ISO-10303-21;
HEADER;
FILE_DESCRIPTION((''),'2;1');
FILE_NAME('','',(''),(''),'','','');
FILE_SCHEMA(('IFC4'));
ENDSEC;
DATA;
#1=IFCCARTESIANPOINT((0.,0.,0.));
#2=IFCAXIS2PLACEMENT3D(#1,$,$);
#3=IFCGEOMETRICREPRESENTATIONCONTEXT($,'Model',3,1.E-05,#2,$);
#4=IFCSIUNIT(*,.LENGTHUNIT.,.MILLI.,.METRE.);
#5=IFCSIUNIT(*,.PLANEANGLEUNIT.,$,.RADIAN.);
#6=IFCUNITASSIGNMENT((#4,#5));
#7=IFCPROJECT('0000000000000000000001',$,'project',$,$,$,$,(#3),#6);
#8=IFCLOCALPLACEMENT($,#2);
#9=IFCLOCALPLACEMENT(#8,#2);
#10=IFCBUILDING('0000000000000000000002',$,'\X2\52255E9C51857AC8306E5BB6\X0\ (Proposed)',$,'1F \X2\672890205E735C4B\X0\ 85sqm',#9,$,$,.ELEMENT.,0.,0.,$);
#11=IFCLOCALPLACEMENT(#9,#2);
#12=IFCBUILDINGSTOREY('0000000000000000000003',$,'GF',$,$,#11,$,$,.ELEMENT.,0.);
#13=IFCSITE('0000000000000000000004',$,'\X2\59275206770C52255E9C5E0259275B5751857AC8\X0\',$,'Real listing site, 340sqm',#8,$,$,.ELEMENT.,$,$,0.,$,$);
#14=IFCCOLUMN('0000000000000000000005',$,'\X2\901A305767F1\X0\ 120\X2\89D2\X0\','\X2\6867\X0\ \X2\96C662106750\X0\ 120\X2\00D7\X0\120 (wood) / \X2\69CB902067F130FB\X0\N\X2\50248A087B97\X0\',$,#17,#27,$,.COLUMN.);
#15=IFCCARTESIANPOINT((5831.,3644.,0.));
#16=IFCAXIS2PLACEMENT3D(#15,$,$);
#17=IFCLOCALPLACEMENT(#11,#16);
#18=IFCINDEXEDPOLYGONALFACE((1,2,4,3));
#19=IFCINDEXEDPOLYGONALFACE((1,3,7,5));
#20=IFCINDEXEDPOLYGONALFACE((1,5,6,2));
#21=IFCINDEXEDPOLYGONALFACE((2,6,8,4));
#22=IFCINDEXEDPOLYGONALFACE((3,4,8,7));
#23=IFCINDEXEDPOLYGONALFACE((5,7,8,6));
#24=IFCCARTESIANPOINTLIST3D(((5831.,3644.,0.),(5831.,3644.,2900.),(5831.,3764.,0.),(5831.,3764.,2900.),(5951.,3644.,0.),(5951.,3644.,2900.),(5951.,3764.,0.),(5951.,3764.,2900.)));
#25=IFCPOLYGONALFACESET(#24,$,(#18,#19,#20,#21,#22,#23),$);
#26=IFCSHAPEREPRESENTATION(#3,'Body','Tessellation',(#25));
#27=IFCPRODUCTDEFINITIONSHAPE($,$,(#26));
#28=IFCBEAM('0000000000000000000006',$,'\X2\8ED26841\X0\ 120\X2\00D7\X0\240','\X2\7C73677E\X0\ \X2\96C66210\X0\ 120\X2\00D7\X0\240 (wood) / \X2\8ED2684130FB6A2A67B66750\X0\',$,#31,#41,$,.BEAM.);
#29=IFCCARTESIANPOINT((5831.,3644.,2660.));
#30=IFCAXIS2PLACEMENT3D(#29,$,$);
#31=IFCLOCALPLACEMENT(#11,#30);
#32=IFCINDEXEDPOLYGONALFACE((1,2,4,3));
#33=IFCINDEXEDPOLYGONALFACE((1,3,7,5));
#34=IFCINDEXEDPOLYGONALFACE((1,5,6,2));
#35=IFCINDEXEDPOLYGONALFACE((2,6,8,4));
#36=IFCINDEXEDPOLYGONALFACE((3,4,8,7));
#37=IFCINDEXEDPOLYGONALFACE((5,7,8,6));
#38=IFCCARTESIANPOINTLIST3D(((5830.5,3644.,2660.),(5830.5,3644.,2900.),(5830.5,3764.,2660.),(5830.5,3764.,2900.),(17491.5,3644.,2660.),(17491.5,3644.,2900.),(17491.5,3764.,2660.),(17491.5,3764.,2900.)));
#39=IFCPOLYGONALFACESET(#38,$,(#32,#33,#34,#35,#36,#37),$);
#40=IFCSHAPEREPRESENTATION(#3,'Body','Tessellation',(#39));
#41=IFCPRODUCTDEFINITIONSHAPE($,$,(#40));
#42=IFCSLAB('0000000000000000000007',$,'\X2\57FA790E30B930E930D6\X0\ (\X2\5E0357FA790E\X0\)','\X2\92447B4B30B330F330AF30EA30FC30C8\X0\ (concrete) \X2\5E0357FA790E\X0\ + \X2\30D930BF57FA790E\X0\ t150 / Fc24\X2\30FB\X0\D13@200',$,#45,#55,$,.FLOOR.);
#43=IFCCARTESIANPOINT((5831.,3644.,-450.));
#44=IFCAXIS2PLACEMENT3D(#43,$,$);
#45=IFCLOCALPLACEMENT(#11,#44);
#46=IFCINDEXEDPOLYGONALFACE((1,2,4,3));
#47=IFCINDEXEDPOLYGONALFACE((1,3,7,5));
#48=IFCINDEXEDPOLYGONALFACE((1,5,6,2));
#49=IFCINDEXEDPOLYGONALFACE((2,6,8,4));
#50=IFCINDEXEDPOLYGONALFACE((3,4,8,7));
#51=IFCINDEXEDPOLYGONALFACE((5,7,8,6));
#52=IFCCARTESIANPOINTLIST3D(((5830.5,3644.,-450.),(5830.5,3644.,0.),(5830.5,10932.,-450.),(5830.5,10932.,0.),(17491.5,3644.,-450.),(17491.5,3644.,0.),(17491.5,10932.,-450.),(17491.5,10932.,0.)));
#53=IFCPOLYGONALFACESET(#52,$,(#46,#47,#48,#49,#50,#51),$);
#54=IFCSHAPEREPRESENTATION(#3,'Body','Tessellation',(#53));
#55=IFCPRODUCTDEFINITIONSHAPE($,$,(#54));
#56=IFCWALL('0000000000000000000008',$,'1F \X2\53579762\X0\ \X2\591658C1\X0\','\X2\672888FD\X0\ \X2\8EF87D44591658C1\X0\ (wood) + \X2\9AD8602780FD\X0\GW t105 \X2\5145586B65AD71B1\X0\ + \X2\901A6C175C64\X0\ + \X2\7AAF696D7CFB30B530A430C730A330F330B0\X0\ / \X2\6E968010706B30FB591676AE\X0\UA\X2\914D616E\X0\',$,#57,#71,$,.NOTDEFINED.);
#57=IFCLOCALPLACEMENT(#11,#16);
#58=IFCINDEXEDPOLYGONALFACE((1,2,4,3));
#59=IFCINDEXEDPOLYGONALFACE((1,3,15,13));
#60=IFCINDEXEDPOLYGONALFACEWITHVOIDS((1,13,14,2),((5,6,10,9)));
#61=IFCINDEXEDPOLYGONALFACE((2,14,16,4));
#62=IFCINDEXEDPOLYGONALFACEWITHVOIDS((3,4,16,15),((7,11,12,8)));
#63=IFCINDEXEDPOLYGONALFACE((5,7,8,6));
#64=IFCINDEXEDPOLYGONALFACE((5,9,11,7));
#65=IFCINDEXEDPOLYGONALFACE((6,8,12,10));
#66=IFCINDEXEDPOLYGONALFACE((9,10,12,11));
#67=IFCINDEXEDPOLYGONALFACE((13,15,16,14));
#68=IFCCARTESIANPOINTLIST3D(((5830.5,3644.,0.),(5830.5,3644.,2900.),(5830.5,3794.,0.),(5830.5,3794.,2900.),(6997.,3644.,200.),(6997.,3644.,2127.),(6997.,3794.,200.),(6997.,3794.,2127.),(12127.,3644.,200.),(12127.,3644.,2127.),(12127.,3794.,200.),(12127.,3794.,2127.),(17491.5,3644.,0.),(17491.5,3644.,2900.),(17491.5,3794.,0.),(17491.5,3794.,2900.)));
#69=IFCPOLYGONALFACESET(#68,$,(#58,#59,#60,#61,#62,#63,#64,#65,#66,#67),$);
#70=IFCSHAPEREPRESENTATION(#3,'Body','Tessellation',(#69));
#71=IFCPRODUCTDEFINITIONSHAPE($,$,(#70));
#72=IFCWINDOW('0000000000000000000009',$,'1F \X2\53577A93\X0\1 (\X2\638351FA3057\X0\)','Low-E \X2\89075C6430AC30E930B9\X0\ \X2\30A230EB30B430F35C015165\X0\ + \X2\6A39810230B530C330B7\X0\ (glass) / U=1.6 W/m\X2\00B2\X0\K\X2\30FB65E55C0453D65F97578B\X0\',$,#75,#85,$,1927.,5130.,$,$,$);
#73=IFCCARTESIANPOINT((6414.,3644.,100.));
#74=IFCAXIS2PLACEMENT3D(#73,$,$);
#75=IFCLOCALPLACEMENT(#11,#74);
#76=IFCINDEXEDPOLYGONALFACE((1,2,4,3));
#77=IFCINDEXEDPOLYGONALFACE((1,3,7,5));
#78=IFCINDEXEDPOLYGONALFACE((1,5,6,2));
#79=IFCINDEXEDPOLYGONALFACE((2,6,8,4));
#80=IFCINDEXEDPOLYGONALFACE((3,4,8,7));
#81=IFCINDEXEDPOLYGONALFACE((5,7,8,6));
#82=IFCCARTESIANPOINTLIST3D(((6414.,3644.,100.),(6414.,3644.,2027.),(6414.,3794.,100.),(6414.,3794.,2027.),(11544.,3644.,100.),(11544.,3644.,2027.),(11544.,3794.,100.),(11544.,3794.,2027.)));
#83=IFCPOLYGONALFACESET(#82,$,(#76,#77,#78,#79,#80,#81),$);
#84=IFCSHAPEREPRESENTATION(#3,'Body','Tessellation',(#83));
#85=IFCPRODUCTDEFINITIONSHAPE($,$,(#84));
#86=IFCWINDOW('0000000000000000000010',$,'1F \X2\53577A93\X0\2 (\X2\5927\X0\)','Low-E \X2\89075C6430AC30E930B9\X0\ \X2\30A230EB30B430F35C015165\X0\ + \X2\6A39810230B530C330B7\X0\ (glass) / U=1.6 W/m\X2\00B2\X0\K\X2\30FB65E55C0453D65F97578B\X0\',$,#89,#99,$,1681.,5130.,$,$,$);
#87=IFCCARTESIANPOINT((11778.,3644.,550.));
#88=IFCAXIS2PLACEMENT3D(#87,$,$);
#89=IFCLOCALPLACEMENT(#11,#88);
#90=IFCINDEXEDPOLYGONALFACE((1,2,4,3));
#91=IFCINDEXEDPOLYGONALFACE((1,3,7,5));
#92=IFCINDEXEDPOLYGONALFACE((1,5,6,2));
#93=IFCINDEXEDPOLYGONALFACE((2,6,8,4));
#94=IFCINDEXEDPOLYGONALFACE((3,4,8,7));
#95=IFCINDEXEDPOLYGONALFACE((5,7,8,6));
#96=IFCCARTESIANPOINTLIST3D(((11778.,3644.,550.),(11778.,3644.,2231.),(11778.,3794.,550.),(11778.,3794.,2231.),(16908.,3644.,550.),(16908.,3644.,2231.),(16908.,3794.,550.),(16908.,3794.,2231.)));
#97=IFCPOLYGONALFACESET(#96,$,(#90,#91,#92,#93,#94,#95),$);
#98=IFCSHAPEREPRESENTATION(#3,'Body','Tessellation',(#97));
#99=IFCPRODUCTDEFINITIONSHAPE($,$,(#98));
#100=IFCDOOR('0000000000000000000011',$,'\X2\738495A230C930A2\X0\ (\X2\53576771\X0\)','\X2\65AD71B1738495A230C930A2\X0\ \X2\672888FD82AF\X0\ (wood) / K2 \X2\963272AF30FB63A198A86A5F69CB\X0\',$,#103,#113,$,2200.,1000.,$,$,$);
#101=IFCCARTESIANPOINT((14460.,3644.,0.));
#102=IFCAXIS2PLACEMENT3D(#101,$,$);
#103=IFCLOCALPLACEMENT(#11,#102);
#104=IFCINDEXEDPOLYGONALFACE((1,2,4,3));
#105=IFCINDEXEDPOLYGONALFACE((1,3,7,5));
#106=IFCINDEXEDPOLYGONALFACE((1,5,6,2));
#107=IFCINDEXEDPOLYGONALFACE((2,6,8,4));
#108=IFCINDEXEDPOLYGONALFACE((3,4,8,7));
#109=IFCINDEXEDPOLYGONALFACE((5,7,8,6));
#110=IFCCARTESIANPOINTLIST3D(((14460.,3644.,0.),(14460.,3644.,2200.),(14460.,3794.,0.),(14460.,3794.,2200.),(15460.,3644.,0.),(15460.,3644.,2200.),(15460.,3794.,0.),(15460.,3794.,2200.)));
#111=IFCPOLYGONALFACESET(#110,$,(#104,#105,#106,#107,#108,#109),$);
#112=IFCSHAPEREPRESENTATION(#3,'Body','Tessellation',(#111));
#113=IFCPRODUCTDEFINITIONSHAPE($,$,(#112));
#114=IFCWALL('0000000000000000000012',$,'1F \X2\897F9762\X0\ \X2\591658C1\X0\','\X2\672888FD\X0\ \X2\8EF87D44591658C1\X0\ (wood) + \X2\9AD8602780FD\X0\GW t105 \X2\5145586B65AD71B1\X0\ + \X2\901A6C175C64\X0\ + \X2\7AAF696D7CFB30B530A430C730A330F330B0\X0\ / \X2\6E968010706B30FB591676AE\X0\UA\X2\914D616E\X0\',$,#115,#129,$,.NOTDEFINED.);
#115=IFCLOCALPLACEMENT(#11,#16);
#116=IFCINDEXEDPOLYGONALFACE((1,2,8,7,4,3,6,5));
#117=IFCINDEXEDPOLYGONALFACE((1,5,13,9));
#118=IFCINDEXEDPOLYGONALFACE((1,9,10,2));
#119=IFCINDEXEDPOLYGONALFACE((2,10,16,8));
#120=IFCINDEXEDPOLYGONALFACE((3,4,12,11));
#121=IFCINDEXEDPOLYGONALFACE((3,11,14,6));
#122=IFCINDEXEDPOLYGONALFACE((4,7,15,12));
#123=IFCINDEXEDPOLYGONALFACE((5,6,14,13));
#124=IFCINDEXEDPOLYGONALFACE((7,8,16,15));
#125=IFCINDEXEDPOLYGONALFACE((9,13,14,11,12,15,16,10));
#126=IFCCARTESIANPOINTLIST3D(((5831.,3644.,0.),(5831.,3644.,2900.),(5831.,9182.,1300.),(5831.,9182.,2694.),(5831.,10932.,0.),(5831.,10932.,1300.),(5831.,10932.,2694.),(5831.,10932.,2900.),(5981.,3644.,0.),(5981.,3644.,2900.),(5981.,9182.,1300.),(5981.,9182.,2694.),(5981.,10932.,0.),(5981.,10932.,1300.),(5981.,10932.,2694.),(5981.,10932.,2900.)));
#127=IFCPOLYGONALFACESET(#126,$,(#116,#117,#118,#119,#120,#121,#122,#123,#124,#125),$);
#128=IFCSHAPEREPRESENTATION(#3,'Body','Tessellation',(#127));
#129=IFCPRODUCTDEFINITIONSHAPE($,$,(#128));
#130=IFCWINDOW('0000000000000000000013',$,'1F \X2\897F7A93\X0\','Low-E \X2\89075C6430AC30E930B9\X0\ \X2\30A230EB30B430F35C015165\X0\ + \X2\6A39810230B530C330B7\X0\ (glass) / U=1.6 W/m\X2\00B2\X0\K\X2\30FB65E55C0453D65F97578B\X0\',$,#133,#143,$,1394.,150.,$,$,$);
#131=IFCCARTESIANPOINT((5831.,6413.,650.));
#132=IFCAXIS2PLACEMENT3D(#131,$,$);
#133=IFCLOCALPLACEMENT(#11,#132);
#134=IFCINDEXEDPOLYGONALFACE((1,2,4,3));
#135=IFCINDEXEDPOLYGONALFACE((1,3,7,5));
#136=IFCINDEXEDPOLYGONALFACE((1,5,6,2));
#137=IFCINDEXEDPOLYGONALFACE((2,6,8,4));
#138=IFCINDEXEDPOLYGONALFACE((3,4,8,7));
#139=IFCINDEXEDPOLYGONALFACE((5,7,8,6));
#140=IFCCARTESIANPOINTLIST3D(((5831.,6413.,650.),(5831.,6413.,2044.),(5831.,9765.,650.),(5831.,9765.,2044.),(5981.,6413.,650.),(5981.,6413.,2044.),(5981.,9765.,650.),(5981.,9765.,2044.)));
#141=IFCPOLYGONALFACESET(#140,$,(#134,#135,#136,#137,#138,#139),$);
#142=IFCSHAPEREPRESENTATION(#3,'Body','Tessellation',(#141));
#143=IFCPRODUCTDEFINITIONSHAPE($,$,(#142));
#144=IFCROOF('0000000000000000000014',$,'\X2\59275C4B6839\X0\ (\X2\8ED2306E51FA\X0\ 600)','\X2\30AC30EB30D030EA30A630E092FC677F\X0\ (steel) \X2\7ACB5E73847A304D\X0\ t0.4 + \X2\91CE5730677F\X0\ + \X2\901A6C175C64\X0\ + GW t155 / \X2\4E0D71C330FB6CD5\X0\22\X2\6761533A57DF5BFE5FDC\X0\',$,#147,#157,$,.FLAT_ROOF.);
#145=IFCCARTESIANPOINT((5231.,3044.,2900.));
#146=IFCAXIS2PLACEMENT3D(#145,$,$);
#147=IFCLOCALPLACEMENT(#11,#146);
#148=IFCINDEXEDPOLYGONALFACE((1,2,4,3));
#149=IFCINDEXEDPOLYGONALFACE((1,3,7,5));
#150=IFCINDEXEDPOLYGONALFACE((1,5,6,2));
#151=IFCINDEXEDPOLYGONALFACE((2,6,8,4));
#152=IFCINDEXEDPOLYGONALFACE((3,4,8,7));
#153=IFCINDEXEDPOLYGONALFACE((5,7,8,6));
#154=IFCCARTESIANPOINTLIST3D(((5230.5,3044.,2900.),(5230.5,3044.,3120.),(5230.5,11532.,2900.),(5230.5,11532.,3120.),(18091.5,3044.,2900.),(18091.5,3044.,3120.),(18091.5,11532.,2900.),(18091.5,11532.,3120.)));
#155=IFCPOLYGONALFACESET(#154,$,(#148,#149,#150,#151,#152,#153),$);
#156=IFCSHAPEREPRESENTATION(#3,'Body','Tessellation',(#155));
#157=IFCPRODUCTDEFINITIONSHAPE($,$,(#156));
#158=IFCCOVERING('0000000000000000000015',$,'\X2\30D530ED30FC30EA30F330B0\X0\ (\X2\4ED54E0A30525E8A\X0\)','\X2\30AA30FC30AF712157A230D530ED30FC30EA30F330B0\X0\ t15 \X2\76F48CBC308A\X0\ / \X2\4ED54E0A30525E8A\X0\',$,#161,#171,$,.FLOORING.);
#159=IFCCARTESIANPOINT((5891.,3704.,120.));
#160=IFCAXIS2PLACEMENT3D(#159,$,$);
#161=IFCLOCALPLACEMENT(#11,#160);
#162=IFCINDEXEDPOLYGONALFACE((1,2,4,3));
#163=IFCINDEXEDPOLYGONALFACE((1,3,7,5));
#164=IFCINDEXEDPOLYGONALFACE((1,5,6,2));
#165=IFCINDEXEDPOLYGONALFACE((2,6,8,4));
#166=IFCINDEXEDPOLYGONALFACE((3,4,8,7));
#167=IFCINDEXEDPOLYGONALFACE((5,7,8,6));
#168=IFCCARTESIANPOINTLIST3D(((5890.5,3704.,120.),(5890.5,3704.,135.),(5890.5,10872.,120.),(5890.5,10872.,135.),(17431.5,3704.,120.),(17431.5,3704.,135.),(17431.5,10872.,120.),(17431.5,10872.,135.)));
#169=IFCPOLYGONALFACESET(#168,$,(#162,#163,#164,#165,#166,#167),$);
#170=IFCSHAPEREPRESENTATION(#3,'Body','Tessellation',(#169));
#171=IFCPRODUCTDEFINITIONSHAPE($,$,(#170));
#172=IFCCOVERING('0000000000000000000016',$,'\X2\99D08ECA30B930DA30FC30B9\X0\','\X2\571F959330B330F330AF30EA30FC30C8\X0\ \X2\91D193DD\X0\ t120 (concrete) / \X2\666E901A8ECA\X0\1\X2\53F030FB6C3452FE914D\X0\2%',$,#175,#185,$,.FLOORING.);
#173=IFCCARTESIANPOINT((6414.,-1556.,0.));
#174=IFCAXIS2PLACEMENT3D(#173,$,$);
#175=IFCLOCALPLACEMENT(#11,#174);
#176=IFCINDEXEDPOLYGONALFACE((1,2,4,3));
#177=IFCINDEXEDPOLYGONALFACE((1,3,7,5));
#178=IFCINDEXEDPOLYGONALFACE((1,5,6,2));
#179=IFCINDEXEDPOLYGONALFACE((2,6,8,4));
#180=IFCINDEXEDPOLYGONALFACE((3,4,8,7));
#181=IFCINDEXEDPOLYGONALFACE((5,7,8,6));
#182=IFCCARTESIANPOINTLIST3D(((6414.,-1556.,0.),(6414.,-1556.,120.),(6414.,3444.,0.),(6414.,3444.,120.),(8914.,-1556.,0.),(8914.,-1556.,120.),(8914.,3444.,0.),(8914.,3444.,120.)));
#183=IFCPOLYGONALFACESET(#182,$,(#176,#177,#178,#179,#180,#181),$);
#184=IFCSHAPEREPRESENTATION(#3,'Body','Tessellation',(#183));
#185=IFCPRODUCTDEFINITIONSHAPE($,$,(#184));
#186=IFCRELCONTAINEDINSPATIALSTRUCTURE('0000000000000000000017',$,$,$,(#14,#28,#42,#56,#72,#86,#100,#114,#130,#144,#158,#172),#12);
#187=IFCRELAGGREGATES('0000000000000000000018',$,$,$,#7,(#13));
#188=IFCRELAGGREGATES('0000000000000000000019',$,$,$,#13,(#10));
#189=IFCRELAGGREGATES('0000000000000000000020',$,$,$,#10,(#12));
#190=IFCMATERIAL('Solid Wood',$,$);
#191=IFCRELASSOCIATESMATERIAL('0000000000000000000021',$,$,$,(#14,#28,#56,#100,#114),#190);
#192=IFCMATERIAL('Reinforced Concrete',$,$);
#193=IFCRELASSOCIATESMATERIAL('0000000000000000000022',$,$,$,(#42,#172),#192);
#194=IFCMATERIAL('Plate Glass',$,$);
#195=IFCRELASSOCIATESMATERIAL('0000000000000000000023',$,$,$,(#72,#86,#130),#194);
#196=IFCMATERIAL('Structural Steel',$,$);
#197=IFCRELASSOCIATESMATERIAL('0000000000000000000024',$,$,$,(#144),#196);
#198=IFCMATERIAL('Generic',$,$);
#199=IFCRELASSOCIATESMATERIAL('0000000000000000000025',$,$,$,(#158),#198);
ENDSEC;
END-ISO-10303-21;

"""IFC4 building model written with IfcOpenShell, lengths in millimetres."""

from ifc_helpers import new_model, si_unit, frame, frame_2d, origin, place, context, project, spatial, rectangle, extrude, material, element, fill, save


model = new_model("IFC4")

# Units and contexts
model_context = context("Model", 3, precision=1e-05, world=origin())
ifc_project = project(units=[si_unit("LENGTHUNIT", "METRE", prefix="MILLI"), si_unit("PLANEANGLEUNIT", "RADIAN")], contexts=[model_context])

# Site, building, storey
site_placement = place(None, origin())
site = spatial("IfcSite", under=ifc_project, at=site_placement, Name="大分県別府市大字内竈", ObjectType="Real listing site, 340sqm", CompositionType="ELEMENT", RefElevation=0.0)
building_placement = place(site_placement, origin())
building = spatial("IfcBuilding", under=site, at=building_placement, Name="別府内竈の家 (Proposed)", ObjectType="1F 木造平屋 85sqm", CompositionType="ELEMENT", ElevationOfRefHeight=0.0, ElevationOfTerrain=0.0)
storey_placement = place(building_placement, origin())
storey = spatial("IfcBuildingStorey", under=building, at=storey_placement, Name="GF", CompositionType="ELEMENT", Elevation=0.0)

# Column
ifc_material_1 = material(Name="Solid Wood")
column_1_placement = place(storey_placement, frame((5831.0, 3644.0, 0.0)))
element("IfcColumn", 1, at=column_1_placement, inside=storey, material=ifc_material_1, Name="通し柱 120角", Description="桧 集成材 120×120 (wood) / 構造柱・N値計算", PredefinedType="COLUMN", context=model_context, shape_type="SweptSolid", body=[
    extrude(rectangle(XDim=120.0, YDim=120.0, at=frame_2d((60.0, 60.0))), frame((5831.0, 3644.0, 0.0)), (0.0, 0.0, 1.0), 2900.0),
])

# Beam
beam_1_placement = place(storey_placement, frame((5831.0, 3644.0, 2660.0)))
element("IfcBeam", 2, at=beam_1_placement, inside=storey, material=ifc_material_1, Name="軒桁 120×240", Description="米松 集成 120×240 (wood) / 軒桁・横架材", PredefinedType="BEAM", context=model_context, shape_type="SweptSolid", body=[
    extrude(rectangle(XDim=11661.0, YDim=120.0, at=frame_2d((5830.0, 60.0))), frame((5831.0, 3644.0, 2660.0)), (0.0, 0.0, 1.0), 240.0),
])

# Slab
ifc_material_2 = material(Name="Reinforced Concrete")
slab_1_placement = place(storey_placement, frame((5831.0, 3644.0, -450.0)))
element("IfcSlab", 3, at=slab_1_placement, inside=storey, material=ifc_material_2, Name="基礎スラブ (布基礎)", Description="鉄筋コンクリート (concrete) 布基礎 + ベタ基礎 t150 / Fc24・D13@200", PredefinedType="FLOOR", context=model_context, shape_type="SweptSolid", body=[
    extrude(rectangle(XDim=11661.0, YDim=7288.0, at=frame_2d((5830.0, 3644.0))), frame((5831.0, 3644.0, -450.0)), (0.0, 0.0, 1.0), 450.0),
])

# Wall, openings, windows, door
wall_1_placement = place(storey_placement, frame((5831.0, 3644.0, 0.0)))
wall_1 = element("IfcWall", 4, at=wall_1_placement, inside=storey, material=ifc_material_1, Name="1F 南面 外壁", Description="木製 軸組外壁 (wood) + 高性能GW t105 充填断熱 + 通気層 + 窯業系サイディング / 準耐火・外皮UA配慮", PredefinedType="NOTDEFINED", context=model_context, shape_type="SweptSolid", body=[
    extrude(rectangle(XDim=11661.0, YDim=150.0, at=frame_2d((5830.0, 75.0))), frame((5831.0, 3644.0, 0.0)), (0.0, 0.0, 1.0), 2900.0),
])
opening_1_placement = place(storey_placement, frame((6414.0, 3644.0, 100.0)))
opening_1 = element("IfcOpeningElement", 5, at=opening_1_placement, cuts=wall_1, PredefinedType="NOTDEFINED", context=model_context, shape_type="SweptSolid", body=[
    extrude(rectangle(XDim=5130.0, YDim=150.0, at=frame_2d((2565.0, 75.0))), frame((6414.0, 3644.0, 100.0)), (0.0, 0.0, 1.0), 1927.0),
])
opening_2_placement = place(storey_placement, frame((11778.0, 3644.0, 550.0)))
opening_2 = element("IfcOpeningElement", 6, at=opening_2_placement, cuts=wall_1, PredefinedType="NOTDEFINED", context=model_context, shape_type="SweptSolid", body=[
    extrude(rectangle(XDim=5130.0, YDim=150.0, at=frame_2d((2565.0, 75.0))), frame((11778.0, 3644.0, 550.0)), (0.0, 0.0, 1.0), 1681.0),
])
opening_3_placement = place(storey_placement, frame((14460.0, 3644.0, 0.0)))
opening_3 = element("IfcOpeningElement", 7, at=opening_3_placement, cuts=wall_1, PredefinedType="NOTDEFINED", context=model_context, shape_type="SweptSolid", body=[
    extrude(rectangle(XDim=1000.0, YDim=150.0, at=frame_2d((500.0, 75.0))), frame((14460.0, 3644.0, 0.0)), (0.0, 0.0, 1.0), 2200.0),
])
ifc_material_3 = material(Name="Plate Glass")
window_1_placement = place(storey_placement, frame((6414.0, 3644.0, 100.0)))
window_1 = element("IfcWindow", 8, at=window_1_placement, inside=storey, material=ifc_material_3, Name="1F 南窓1 (掃出し)", Description="Low-E 複層ガラス アルゴン封入 + 樹脂サッシ (glass) / U=1.6 W/m²K・日射取得型", OverallHeight=1927.0, OverallWidth=5130.0, context=model_context, shape_type="SweptSolid", body=[
    extrude(rectangle(XDim=5130.0, YDim=150.0, at=frame_2d((2565.0, 75.0))), frame((6414.0, 3644.0, 100.0)), (0.0, 0.0, 1.0), 1927.0),
])
fill(opening_1, window_1)
window_2_placement = place(storey_placement, frame((11778.0, 3644.0, 550.0)))
window_2 = element("IfcWindow", 9, at=window_2_placement, inside=storey, material=ifc_material_3, Name="1F 南窓2 (大)", Description="Low-E 複層ガラス アルゴン封入 + 樹脂サッシ (glass) / U=1.6 W/m²K・日射取得型", OverallHeight=1681.0, OverallWidth=5130.0, context=model_context, shape_type="SweptSolid", body=[
    extrude(rectangle(XDim=5130.0, YDim=150.0, at=frame_2d((2565.0, 75.0))), frame((11778.0, 3644.0, 550.0)), (0.0, 0.0, 1.0), 1681.0),
])
fill(opening_2, window_2)
door_placement = place(storey_placement, frame((14460.0, 3644.0, 0.0)))
door = element("IfcDoor", 10, at=door_placement, inside=storey, material=ifc_material_1, Name="玄関ドア (南東)", Description="断熱玄関ドア 木製芯 (wood) / K2 防犯・採風機構", OverallHeight=2200.0, OverallWidth=1000.0, context=model_context, shape_type="SweptSolid", body=[
    extrude(rectangle(XDim=1000.0, YDim=150.0, at=frame_2d((500.0, 75.0))), frame((14460.0, 3644.0, 0.0)), (0.0, 0.0, 1.0), 2200.0),
])
fill(opening_3, door)

# Wall, opening, window
wall_2_placement = place(storey_placement, frame((5831.0, 3644.0, 0.0)))
wall_2 = element("IfcWall", 11, at=wall_2_placement, inside=storey, material=ifc_material_1, Name="1F 西面 外壁", Description="木製 軸組外壁 (wood) + 高性能GW t105 充填断熱 + 通気層 + 窯業系サイディング / 準耐火・外皮UA配慮", PredefinedType="NOTDEFINED", context=model_context, shape_type="SweptSolid", body=[
    extrude(rectangle(XDim=150.0, YDim=7288.0, at=frame_2d((75.0, 3644.0))), frame((5831.0, 3644.0, 0.0)), (0.0, 0.0, 1.0), 2900.0),
])
opening_4_placement = place(storey_placement, frame((5831.0, 6413.0, 650.0)))
opening_4 = element("IfcOpeningElement", 12, at=opening_4_placement, cuts=wall_2, PredefinedType="NOTDEFINED", context=model_context, shape_type="SweptSolid", body=[
    extrude(rectangle(XDim=150.0, YDim=3352.0, at=frame_2d((75.0, 1676.0))), frame((5831.0, 6413.0, 650.0)), (0.0, 0.0, 1.0), 1394.0),
])
window_3_placement = place(storey_placement, frame((5831.0, 6413.0, 650.0)))
window_3 = element("IfcWindow", 13, at=window_3_placement, inside=storey, material=ifc_material_3, Name="1F 西窓", Description="Low-E 複層ガラス アルゴン封入 + 樹脂サッシ (glass) / U=1.6 W/m²K・日射取得型", OverallHeight=1394.0, OverallWidth=150.0, context=model_context, shape_type="SweptSolid", body=[
    extrude(rectangle(XDim=150.0, YDim=3352.0, at=frame_2d((75.0, 1676.0))), frame((5831.0, 6413.0, 650.0)), (0.0, 0.0, 1.0), 1394.0),
])
fill(opening_4, window_3)

# Roof
ifc_material_4 = material(Name="Structural Steel")
roof_placement = place(storey_placement, frame((5231.0, 3044.0, 2900.0)))
element("IfcRoof", 14, at=roof_placement, inside=storey, material=ifc_material_4, Name="大屋根 (軒の出 600)", Description="ガルバリウム鋼板 (steel) 立平葺き t0.4 + 野地板 + 通気層 + GW t155 / 不燃・法22条区域対応", PredefinedType="FLAT_ROOF", context=model_context, shape_type="SweptSolid", body=[
    extrude(rectangle(XDim=12861.0, YDim=8488.0, at=frame_2d((6430.0, 4244.0))), frame((5231.0, 3044.0, 2900.0)), (0.0, 0.0, 1.0), 220.0),
])

# Coverings
ifc_material_5 = material(Name="Generic")
covering_1_placement = place(storey_placement, frame((5891.0, 3704.0, 120.0)))
element("IfcCovering", 15, at=covering_1_placement, inside=storey, material=ifc_material_5, Name="フローリング (仕上げ床)", Description="オーク無垢フローリング t15 直貼り / 仕上げ床", PredefinedType="FLOORING", context=model_context, shape_type="SweptSolid", body=[
    extrude(rectangle(XDim=11541.0, YDim=7168.0, at=frame_2d((5770.0, 3584.0))), frame((5891.0, 3704.0, 120.0)), (0.0, 0.0, 1.0), 15.0),
])
covering_2_placement = place(storey_placement, frame((6414.0, -1556.0, 0.0)))
element("IfcCovering", 16, at=covering_2_placement, inside=storey, material=ifc_material_2, Name="駐車スペース", Description="土間コンクリート 金鏝 t120 (concrete) / 普通車1台・水勾配2%", PredefinedType="FLOORING", context=model_context, shape_type="SweptSolid", body=[
    extrude(rectangle(XDim=2500.0, YDim=5000.0, at=frame_2d((1250.0, 2500.0))), frame((6414.0, -1556.0, 0.0)), (0.0, 0.0, 1.0), 120.0),
])

save(model, "model.ifc")
